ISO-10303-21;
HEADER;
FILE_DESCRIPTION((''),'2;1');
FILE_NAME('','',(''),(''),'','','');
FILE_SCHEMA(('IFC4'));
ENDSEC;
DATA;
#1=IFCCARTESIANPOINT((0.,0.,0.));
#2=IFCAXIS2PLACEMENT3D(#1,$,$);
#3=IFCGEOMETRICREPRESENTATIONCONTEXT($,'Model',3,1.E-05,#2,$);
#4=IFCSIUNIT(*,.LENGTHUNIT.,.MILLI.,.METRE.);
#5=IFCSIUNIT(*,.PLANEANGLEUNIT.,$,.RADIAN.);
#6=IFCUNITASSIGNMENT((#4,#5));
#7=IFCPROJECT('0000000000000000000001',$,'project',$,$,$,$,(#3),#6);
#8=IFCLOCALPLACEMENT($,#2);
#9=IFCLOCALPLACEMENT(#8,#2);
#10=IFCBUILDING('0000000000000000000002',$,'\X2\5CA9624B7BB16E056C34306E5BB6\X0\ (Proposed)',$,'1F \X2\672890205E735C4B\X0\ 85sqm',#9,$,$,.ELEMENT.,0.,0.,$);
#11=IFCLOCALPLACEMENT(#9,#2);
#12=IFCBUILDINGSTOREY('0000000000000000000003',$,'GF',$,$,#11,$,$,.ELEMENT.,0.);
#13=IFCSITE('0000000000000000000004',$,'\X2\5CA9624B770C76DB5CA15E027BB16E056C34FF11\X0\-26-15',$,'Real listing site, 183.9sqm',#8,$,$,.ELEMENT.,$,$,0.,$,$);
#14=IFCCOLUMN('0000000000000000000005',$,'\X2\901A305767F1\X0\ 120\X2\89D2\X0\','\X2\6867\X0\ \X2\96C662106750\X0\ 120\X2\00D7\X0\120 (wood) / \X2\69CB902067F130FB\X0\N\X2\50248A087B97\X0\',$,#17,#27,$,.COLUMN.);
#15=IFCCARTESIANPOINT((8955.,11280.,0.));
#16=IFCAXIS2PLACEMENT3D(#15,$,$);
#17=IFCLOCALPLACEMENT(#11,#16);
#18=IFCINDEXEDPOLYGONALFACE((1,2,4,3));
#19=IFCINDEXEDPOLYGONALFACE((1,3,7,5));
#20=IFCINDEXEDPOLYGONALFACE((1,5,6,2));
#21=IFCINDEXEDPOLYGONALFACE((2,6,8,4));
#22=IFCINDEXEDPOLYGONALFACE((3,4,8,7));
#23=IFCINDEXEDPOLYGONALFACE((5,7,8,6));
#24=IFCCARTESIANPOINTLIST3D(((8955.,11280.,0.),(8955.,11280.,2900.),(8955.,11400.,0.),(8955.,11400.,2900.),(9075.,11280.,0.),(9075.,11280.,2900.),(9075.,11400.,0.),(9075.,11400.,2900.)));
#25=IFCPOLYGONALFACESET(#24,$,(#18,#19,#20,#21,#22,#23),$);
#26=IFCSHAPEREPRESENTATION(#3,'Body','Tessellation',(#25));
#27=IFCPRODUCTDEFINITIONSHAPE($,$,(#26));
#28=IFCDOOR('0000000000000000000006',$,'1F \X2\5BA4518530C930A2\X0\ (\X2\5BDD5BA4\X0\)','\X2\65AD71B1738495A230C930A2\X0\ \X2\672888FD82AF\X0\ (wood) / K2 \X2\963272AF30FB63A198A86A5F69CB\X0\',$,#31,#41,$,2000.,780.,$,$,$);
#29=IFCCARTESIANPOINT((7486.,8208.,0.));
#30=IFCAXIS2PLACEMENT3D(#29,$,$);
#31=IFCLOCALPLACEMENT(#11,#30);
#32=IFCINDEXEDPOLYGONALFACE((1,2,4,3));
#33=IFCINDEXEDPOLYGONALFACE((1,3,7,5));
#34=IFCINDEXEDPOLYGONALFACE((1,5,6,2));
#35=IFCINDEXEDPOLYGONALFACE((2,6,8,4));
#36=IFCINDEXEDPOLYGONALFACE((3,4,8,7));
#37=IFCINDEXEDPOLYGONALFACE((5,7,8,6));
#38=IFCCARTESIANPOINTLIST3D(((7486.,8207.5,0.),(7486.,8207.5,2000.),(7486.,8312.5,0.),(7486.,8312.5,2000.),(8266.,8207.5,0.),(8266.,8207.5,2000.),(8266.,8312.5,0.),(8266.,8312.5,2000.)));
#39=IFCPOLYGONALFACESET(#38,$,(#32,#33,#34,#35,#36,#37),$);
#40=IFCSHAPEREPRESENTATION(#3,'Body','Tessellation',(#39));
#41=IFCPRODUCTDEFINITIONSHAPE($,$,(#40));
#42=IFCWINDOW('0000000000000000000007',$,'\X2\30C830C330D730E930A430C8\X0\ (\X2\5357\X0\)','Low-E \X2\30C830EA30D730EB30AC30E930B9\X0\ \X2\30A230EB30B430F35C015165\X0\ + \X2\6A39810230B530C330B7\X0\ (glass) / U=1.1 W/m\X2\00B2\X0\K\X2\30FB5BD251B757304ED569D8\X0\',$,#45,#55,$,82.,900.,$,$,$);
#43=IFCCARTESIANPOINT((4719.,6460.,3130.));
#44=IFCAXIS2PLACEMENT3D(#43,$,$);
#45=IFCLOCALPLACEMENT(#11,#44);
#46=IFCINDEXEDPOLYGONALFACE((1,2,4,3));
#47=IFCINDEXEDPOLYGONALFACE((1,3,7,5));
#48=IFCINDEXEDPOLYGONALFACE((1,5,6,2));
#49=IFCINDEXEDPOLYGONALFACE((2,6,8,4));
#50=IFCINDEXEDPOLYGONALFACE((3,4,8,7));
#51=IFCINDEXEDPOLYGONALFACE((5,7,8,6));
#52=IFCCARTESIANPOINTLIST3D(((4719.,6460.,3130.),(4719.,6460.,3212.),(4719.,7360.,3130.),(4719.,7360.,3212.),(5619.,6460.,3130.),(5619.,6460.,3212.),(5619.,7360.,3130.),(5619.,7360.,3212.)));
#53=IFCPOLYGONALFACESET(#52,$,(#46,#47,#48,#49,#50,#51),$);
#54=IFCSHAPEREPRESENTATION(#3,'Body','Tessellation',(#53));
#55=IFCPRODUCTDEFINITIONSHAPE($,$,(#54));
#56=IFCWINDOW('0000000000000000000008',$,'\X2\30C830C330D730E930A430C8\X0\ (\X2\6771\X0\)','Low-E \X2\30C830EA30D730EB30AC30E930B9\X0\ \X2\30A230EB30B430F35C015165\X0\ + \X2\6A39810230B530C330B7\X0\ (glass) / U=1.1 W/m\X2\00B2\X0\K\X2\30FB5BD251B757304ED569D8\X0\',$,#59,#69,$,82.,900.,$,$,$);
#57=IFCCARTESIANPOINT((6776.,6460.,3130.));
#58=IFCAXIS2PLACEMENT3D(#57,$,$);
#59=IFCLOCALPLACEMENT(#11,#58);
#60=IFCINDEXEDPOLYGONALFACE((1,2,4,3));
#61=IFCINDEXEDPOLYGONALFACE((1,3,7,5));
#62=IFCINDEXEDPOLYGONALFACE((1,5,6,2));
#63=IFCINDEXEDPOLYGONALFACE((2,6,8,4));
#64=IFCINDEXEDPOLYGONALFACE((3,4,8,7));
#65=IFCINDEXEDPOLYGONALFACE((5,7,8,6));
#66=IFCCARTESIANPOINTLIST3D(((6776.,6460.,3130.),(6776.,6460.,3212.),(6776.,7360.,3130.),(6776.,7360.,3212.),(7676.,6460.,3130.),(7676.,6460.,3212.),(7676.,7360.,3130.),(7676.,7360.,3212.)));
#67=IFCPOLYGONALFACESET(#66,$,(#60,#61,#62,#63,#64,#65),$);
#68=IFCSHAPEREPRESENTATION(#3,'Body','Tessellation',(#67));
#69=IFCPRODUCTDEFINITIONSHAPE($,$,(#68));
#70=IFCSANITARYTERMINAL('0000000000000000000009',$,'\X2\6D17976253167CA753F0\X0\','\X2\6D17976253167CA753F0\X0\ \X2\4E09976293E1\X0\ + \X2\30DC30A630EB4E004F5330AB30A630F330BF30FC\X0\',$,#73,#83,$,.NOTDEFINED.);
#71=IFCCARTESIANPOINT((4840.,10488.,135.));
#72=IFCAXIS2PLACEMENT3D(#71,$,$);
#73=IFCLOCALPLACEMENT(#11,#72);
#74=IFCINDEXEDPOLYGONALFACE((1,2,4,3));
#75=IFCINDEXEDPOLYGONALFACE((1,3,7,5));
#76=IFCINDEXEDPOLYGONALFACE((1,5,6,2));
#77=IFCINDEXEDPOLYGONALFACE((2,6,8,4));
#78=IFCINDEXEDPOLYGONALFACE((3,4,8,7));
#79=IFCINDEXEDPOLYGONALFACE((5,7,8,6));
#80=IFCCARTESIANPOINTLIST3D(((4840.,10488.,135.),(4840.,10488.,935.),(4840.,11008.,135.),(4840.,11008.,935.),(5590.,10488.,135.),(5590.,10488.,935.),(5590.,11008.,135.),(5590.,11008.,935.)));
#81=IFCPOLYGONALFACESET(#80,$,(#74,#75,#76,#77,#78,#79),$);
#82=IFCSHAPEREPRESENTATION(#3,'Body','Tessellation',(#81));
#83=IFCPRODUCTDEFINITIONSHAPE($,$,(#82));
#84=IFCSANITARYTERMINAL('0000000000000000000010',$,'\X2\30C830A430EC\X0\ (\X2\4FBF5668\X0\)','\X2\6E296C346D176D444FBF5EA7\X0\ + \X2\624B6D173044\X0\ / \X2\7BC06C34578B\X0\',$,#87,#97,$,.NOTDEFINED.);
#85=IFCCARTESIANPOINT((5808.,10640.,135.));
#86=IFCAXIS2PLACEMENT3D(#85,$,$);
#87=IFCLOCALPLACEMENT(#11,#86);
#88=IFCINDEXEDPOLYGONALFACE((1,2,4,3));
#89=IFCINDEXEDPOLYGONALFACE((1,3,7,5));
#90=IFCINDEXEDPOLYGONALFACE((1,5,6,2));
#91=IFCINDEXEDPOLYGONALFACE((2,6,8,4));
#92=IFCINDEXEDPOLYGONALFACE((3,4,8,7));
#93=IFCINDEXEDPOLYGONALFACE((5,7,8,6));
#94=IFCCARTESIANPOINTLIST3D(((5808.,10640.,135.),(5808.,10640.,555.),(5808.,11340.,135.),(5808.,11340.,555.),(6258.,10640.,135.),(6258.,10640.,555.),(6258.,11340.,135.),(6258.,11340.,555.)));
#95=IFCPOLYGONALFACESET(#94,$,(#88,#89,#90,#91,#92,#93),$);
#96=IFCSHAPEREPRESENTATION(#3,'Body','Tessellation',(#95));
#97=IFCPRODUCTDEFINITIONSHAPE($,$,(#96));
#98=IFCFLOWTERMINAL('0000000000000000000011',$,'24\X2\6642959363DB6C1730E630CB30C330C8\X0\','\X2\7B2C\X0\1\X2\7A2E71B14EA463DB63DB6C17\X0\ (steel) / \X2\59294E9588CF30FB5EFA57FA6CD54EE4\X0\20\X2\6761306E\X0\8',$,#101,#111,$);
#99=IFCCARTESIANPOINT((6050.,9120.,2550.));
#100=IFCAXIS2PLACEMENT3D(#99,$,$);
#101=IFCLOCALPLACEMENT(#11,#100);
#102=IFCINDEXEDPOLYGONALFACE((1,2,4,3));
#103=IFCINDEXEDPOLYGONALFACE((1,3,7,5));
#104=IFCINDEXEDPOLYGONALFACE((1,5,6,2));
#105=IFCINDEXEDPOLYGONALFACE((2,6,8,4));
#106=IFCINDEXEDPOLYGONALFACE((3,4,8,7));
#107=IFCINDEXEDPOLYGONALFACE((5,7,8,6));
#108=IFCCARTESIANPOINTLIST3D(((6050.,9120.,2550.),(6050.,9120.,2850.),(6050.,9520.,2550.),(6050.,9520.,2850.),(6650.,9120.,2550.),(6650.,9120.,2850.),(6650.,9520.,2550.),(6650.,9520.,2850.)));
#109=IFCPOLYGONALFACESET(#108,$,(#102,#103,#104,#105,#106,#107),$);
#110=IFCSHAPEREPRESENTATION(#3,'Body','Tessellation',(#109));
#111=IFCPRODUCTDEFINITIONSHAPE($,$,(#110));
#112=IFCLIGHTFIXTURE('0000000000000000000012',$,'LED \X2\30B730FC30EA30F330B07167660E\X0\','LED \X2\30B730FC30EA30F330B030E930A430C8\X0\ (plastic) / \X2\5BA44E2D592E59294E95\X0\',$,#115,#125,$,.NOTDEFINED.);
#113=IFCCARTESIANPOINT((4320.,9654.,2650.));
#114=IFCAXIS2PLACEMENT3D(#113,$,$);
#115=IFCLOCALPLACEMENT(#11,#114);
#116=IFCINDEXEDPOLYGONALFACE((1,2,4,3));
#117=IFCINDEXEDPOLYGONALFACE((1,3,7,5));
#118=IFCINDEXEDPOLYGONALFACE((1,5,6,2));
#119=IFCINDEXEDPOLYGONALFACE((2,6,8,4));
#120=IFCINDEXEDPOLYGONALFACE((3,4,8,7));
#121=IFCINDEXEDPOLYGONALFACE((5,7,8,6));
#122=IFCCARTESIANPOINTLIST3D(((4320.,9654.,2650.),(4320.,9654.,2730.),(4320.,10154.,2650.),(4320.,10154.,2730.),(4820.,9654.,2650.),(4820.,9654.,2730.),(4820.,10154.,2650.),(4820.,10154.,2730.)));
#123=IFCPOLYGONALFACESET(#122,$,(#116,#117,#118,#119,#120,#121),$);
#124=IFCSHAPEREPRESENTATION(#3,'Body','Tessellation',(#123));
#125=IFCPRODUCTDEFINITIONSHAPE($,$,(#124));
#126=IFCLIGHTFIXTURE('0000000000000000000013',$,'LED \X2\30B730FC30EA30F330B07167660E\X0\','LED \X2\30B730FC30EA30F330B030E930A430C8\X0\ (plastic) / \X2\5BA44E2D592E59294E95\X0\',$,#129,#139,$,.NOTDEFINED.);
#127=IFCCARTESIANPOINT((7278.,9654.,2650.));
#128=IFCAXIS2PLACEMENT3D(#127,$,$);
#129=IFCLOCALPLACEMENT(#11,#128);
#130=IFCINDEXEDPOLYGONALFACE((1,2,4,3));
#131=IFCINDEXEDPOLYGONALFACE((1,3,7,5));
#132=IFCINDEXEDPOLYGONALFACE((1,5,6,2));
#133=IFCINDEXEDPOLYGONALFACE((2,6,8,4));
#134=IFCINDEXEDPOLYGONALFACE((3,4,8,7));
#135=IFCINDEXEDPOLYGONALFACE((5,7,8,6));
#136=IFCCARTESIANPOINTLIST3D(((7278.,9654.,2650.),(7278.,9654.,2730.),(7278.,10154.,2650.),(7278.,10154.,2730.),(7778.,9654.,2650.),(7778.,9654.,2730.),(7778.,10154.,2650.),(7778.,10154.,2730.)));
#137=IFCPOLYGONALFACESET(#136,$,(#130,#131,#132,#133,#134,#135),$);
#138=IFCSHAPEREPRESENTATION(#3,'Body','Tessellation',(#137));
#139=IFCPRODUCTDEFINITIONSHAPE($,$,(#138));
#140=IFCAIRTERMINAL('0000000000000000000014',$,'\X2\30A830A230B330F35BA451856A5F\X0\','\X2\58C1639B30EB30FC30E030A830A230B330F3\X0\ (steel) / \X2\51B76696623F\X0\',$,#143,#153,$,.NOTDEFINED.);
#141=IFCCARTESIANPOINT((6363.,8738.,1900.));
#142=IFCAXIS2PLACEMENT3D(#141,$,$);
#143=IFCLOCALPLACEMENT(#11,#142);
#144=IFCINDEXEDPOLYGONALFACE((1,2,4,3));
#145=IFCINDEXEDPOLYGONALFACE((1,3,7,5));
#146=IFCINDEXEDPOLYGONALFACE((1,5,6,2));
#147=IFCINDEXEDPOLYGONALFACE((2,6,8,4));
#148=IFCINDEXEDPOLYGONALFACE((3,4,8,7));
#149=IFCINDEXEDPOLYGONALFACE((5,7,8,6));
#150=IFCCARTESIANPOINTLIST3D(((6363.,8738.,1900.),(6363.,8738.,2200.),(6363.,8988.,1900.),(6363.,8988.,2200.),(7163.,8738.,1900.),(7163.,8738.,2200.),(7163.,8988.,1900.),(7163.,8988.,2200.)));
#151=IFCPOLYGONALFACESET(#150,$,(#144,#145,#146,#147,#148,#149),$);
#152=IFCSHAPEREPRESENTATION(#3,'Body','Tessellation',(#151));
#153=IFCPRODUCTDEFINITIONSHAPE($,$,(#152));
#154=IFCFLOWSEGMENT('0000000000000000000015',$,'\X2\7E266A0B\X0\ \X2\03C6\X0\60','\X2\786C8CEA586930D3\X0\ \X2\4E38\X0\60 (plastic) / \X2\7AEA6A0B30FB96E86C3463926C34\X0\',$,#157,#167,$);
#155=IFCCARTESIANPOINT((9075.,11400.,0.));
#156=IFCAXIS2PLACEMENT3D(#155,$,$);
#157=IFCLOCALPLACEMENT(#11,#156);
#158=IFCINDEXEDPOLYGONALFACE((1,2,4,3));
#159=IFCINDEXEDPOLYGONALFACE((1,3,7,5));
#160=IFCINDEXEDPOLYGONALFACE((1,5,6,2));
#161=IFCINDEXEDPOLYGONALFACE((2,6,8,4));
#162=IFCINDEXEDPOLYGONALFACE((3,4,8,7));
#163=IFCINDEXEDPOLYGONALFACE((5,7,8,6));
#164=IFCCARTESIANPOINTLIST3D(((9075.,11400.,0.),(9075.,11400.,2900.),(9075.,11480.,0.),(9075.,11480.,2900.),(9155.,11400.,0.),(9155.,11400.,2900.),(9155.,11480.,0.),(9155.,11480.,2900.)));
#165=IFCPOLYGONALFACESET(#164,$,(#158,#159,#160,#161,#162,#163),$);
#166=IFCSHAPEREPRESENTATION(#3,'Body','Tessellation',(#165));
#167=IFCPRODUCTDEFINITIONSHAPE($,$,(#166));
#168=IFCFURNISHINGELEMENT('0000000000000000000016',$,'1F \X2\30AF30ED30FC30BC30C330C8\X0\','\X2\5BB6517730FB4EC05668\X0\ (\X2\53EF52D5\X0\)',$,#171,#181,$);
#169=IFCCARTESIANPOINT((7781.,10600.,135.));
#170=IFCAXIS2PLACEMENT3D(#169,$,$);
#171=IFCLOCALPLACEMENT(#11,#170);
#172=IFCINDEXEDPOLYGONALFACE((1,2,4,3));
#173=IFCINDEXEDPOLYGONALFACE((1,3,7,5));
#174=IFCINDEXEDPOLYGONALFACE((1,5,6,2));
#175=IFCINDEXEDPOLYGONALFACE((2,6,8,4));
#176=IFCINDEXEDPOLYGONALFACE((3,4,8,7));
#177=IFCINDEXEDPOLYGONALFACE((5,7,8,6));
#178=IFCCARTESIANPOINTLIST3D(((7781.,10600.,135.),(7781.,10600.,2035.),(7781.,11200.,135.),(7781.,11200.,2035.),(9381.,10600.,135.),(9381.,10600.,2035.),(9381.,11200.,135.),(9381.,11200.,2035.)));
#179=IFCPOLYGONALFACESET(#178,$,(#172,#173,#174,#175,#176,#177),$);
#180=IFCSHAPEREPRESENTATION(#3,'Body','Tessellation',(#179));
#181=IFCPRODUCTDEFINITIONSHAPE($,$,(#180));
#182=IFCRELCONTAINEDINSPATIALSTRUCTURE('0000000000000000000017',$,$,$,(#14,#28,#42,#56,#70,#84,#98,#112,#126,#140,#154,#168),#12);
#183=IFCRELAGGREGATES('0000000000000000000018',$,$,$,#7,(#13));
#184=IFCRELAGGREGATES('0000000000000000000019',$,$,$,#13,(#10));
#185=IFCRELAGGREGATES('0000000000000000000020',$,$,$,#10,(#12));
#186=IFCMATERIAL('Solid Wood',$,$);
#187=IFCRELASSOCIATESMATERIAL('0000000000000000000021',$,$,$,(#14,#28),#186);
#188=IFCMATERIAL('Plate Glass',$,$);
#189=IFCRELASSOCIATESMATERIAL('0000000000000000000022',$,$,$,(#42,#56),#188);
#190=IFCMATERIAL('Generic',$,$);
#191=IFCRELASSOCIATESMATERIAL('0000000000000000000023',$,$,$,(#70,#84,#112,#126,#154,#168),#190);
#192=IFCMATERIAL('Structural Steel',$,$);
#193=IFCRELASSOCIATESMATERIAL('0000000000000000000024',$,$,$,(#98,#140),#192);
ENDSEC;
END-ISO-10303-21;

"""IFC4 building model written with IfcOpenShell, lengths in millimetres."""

from ifc_helpers import new_model, si_unit, frame, frame_2d, origin, place, context, project, spatial, rectangle, extrude, material, element, save


model = new_model("IFC4")

# Units and contexts
model_context = context("Model", 3, precision=1e-05, world=origin())
ifc_project = project(units=[si_unit("LENGTHUNIT", "METRE", prefix="MILLI"), si_unit("PLANEANGLEUNIT", "RADIAN")], contexts=[model_context])

# Site, building, storey
site_placement = place(None, origin())
site = spatial("IfcSite", under=ifc_project, at=site_placement, Name="岩手県盛岡市箱清水１-26-15", ObjectType="Real listing site, 183.9sqm", CompositionType="ELEMENT", RefElevation=0.0)
building_placement = place(site_placement, origin())
building = spatial("IfcBuilding", under=site, at=building_placement, Name="岩手箱清水の家 (Proposed)", ObjectType="1F 木造平屋 85sqm", CompositionType="ELEMENT", ElevationOfRefHeight=0.0, ElevationOfTerrain=0.0)
storey_placement = place(building_placement, origin())
storey = spatial("IfcBuildingStorey", under=building, at=storey_placement, Name="GF", CompositionType="ELEMENT", Elevation=0.0)

# Column
ifc_material_1 = material(Name="Solid Wood")
column_1_placement = place(storey_placement, frame((8955.0, 11280.0, 0.0)))
element("IfcColumn", 1, at=column_1_placement, inside=storey, material=ifc_material_1, Name="通し柱 120角", Description="桧 集成材 120×120 (wood) / 構造柱・N値計算", PredefinedType="COLUMN", context=model_context, shape_type="SweptSolid", body=[
    extrude(rectangle(XDim=120.0, YDim=120.0, at=frame_2d((60.0, 60.0))), frame((8955.0, 11280.0, 0.0)), (0.0, 0.0, 1.0), 2900.0),
])

# Door
door_placement = place(storey_placement, frame((7486.0, 8208.0, 0.0)))
element("IfcDoor", 2, at=door_placement, inside=storey, material=ifc_material_1, Name="1F 室内ドア (寝室)", Description="断熱玄関ドア 木製芯 (wood) / K2 防犯・採風機構", OverallHeight=2000.0, OverallWidth=780.0, context=model_context, shape_type="SweptSolid", body=[
    extrude(rectangle(XDim=780.0, YDim=105.0, at=frame_2d((390.0, 52.0))), frame((7486.0, 8208.0, 0.0)), (0.0, 0.0, 1.0), 2000.0),
])

# Windows
ifc_material_2 = material(Name="Plate Glass")
window_1_placement = place(storey_placement, frame((4719.0, 6460.0, 3130.0)))
element("IfcWindow", 3, at=window_1_placement, inside=storey, material=ifc_material_2, Name="トップライト (南)", Description="Low-E トリプルガラス アルゴン封入 + 樹脂サッシ (glass) / U=1.1 W/m²K・寒冷地仕様", OverallHeight=82.0, OverallWidth=900.0, context=model_context, shape_type="SweptSolid", body=[
    extrude(rectangle(XDim=900.0, YDim=900.0, at=frame_2d((450.0, 450.0))), frame((4719.0, 6460.0, 3130.0)), (0.0, 0.0, 1.0), 82.0),
])
window_2_placement = place(storey_placement, frame((6776.0, 6460.0, 3130.0)))
element("IfcWindow", 4, at=window_2_placement, inside=storey, material=ifc_material_2, Name="トップライト (東)", Description="Low-E トリプルガラス アルゴン封入 + 樹脂サッシ (glass) / U=1.1 W/m²K・寒冷地仕様", OverallHeight=82.0, OverallWidth=900.0, context=model_context, shape_type="SweptSolid", body=[
    extrude(rectangle(XDim=900.0, YDim=900.0, at=frame_2d((450.0, 450.0))), frame((6776.0, 6460.0, 3130.0)), (0.0, 0.0, 1.0), 82.0),
])

# Sanitary terminals
ifc_material_3 = material(Name="Generic")
sanitary_terminal_1_placement = place(storey_placement, frame((4840.0, 10488.0, 135.0)))
element("IfcSanitaryTerminal", 5, at=sanitary_terminal_1_placement, inside=storey, material=ifc_material_3, Name="洗面化粧台", Description="洗面化粧台 三面鏡 + ボウル一体カウンター", PredefinedType="NOTDEFINED", context=model_context, shape_type="SweptSolid", body=[
    extrude(rectangle(XDim=750.0, YDim=520.0, at=frame_2d((375.0, 260.0))), frame((4840.0, 10488.0, 135.0)), (0.0, 0.0, 1.0), 800.0),
])
sanitary_terminal_2_placement = place(storey_placement, frame((5808.0, 10640.0, 135.0)))
element("IfcSanitaryTerminal", 6, at=sanitary_terminal_2_placement, inside=storey, material=ifc_material_3, Name="トイレ (便器)", Description="温水洗浄便座 + 手洗い / 節水型", PredefinedType="NOTDEFINED", context=model_context, shape_type="SweptSolid", body=[
    extrude(rectangle(XDim=450.0, YDim=700.0, at=frame_2d((225.0, 350.0))), frame((5808.0, 10640.0, 135.0)), (0.0, 0.0, 1.0), 420.0),
])

# Flow terminal
ifc_material_4 = material(Name="Structural Steel")
flow_terminal_placement = place(storey_placement, frame((6050.0, 9120.0, 2550.0)))
element("IfcFlowTerminal", 7, at=flow_terminal_placement, inside=storey, material=ifc_material_4, Name="24時間換気ユニット", Description="第1種熱交換換気 (steel) / 天井裏・建基法令20条の8", context=model_context, shape_type="SweptSolid", body=[
    extrude(rectangle(XDim=600.0, YDim=400.0, at=frame_2d((300.0, 200.0))), frame((6050.0, 9120.0, 2550.0)), (0.0, 0.0, 1.0), 300.0),
])

# Light fixtures
light_fixture_1_placement = place(storey_placement, frame((4320.0, 9654.0, 2650.0)))
element("IfcLightFixture", 8, at=light_fixture_1_placement, inside=storey, material=ifc_material_3, Name="LED シーリング照明", Description="LED シーリングライト (plastic) / 室中央天井", PredefinedType="NOTDEFINED", context=model_context, shape_type="SweptSolid", body=[
    extrude(rectangle(XDim=500.0, YDim=500.0, at=frame_2d((250.0, 250.0))), frame((4320.0, 9654.0, 2650.0)), (0.0, 0.0, 1.0), 80.0),
])
light_fixture_2_placement = place(storey_placement, frame((7278.0, 9654.0, 2650.0)))
element("IfcLightFixture", 9, at=light_fixture_2_placement, inside=storey, material=ifc_material_3, Name="LED シーリング照明", Description="LED シーリングライト (plastic) / 室中央天井", PredefinedType="NOTDEFINED", context=model_context, shape_type="SweptSolid", body=[
    extrude(rectangle(XDim=500.0, YDim=500.0, at=frame_2d((250.0, 250.0))), frame((7278.0, 9654.0, 2650.0)), (0.0, 0.0, 1.0), 80.0),
])

# Air terminal
air_terminal_placement = place(storey_placement, frame((6363.0, 8738.0, 1900.0)))
element("IfcAirTerminal", 10, at=air_terminal_placement, inside=storey, material=ifc_material_4, Name="エアコン室内機", Description="壁掛ルームエアコン (steel) / 冷暖房", PredefinedType="NOTDEFINED", context=model_context, shape_type="SweptSolid", body=[
    extrude(rectangle(XDim=800.0, YDim=250.0, at=frame_2d((400.0, 125.0))), frame((6363.0, 8738.0, 1900.0)), (0.0, 0.0, 1.0), 300.0),
])

# Flow segment
flow_segment_placement = place(storey_placement, frame((9075.0, 11400.0, 0.0)))
element("IfcFlowSegment", 11, at=flow_segment_placement, inside=storey, material=ifc_material_3, Name="縦樋 φ60", Description="硬質塩ビ 丸60 (plastic) / 竪樋・雨水排水", context=model_context, shape_type="SweptSolid", body=[
    extrude(rectangle(XDim=80.0, YDim=80.0, at=frame_2d((40.0, 40.0))), frame((9075.0, 11400.0, 0.0)), (0.0, 0.0, 1.0), 2900.0),
])

# Furnishing element
furnishing_placement = place(storey_placement, frame((7781.0, 10600.0, 135.0)))
element("IfcFurnishingElement", 12, at=furnishing_placement, inside=storey, material=ifc_material_3, Name="1F クローゼット", Description="家具・什器 (可動)", context=model_context, shape_type="SweptSolid", body=[
    extrude(rectangle(XDim=1600.0, YDim=600.0, at=frame_2d((800.0, 300.0))), frame((7781.0, 10600.0, 135.0)), (0.0, 0.0, 1.0), 1900.0),
])

save(model, "model.ifc")
